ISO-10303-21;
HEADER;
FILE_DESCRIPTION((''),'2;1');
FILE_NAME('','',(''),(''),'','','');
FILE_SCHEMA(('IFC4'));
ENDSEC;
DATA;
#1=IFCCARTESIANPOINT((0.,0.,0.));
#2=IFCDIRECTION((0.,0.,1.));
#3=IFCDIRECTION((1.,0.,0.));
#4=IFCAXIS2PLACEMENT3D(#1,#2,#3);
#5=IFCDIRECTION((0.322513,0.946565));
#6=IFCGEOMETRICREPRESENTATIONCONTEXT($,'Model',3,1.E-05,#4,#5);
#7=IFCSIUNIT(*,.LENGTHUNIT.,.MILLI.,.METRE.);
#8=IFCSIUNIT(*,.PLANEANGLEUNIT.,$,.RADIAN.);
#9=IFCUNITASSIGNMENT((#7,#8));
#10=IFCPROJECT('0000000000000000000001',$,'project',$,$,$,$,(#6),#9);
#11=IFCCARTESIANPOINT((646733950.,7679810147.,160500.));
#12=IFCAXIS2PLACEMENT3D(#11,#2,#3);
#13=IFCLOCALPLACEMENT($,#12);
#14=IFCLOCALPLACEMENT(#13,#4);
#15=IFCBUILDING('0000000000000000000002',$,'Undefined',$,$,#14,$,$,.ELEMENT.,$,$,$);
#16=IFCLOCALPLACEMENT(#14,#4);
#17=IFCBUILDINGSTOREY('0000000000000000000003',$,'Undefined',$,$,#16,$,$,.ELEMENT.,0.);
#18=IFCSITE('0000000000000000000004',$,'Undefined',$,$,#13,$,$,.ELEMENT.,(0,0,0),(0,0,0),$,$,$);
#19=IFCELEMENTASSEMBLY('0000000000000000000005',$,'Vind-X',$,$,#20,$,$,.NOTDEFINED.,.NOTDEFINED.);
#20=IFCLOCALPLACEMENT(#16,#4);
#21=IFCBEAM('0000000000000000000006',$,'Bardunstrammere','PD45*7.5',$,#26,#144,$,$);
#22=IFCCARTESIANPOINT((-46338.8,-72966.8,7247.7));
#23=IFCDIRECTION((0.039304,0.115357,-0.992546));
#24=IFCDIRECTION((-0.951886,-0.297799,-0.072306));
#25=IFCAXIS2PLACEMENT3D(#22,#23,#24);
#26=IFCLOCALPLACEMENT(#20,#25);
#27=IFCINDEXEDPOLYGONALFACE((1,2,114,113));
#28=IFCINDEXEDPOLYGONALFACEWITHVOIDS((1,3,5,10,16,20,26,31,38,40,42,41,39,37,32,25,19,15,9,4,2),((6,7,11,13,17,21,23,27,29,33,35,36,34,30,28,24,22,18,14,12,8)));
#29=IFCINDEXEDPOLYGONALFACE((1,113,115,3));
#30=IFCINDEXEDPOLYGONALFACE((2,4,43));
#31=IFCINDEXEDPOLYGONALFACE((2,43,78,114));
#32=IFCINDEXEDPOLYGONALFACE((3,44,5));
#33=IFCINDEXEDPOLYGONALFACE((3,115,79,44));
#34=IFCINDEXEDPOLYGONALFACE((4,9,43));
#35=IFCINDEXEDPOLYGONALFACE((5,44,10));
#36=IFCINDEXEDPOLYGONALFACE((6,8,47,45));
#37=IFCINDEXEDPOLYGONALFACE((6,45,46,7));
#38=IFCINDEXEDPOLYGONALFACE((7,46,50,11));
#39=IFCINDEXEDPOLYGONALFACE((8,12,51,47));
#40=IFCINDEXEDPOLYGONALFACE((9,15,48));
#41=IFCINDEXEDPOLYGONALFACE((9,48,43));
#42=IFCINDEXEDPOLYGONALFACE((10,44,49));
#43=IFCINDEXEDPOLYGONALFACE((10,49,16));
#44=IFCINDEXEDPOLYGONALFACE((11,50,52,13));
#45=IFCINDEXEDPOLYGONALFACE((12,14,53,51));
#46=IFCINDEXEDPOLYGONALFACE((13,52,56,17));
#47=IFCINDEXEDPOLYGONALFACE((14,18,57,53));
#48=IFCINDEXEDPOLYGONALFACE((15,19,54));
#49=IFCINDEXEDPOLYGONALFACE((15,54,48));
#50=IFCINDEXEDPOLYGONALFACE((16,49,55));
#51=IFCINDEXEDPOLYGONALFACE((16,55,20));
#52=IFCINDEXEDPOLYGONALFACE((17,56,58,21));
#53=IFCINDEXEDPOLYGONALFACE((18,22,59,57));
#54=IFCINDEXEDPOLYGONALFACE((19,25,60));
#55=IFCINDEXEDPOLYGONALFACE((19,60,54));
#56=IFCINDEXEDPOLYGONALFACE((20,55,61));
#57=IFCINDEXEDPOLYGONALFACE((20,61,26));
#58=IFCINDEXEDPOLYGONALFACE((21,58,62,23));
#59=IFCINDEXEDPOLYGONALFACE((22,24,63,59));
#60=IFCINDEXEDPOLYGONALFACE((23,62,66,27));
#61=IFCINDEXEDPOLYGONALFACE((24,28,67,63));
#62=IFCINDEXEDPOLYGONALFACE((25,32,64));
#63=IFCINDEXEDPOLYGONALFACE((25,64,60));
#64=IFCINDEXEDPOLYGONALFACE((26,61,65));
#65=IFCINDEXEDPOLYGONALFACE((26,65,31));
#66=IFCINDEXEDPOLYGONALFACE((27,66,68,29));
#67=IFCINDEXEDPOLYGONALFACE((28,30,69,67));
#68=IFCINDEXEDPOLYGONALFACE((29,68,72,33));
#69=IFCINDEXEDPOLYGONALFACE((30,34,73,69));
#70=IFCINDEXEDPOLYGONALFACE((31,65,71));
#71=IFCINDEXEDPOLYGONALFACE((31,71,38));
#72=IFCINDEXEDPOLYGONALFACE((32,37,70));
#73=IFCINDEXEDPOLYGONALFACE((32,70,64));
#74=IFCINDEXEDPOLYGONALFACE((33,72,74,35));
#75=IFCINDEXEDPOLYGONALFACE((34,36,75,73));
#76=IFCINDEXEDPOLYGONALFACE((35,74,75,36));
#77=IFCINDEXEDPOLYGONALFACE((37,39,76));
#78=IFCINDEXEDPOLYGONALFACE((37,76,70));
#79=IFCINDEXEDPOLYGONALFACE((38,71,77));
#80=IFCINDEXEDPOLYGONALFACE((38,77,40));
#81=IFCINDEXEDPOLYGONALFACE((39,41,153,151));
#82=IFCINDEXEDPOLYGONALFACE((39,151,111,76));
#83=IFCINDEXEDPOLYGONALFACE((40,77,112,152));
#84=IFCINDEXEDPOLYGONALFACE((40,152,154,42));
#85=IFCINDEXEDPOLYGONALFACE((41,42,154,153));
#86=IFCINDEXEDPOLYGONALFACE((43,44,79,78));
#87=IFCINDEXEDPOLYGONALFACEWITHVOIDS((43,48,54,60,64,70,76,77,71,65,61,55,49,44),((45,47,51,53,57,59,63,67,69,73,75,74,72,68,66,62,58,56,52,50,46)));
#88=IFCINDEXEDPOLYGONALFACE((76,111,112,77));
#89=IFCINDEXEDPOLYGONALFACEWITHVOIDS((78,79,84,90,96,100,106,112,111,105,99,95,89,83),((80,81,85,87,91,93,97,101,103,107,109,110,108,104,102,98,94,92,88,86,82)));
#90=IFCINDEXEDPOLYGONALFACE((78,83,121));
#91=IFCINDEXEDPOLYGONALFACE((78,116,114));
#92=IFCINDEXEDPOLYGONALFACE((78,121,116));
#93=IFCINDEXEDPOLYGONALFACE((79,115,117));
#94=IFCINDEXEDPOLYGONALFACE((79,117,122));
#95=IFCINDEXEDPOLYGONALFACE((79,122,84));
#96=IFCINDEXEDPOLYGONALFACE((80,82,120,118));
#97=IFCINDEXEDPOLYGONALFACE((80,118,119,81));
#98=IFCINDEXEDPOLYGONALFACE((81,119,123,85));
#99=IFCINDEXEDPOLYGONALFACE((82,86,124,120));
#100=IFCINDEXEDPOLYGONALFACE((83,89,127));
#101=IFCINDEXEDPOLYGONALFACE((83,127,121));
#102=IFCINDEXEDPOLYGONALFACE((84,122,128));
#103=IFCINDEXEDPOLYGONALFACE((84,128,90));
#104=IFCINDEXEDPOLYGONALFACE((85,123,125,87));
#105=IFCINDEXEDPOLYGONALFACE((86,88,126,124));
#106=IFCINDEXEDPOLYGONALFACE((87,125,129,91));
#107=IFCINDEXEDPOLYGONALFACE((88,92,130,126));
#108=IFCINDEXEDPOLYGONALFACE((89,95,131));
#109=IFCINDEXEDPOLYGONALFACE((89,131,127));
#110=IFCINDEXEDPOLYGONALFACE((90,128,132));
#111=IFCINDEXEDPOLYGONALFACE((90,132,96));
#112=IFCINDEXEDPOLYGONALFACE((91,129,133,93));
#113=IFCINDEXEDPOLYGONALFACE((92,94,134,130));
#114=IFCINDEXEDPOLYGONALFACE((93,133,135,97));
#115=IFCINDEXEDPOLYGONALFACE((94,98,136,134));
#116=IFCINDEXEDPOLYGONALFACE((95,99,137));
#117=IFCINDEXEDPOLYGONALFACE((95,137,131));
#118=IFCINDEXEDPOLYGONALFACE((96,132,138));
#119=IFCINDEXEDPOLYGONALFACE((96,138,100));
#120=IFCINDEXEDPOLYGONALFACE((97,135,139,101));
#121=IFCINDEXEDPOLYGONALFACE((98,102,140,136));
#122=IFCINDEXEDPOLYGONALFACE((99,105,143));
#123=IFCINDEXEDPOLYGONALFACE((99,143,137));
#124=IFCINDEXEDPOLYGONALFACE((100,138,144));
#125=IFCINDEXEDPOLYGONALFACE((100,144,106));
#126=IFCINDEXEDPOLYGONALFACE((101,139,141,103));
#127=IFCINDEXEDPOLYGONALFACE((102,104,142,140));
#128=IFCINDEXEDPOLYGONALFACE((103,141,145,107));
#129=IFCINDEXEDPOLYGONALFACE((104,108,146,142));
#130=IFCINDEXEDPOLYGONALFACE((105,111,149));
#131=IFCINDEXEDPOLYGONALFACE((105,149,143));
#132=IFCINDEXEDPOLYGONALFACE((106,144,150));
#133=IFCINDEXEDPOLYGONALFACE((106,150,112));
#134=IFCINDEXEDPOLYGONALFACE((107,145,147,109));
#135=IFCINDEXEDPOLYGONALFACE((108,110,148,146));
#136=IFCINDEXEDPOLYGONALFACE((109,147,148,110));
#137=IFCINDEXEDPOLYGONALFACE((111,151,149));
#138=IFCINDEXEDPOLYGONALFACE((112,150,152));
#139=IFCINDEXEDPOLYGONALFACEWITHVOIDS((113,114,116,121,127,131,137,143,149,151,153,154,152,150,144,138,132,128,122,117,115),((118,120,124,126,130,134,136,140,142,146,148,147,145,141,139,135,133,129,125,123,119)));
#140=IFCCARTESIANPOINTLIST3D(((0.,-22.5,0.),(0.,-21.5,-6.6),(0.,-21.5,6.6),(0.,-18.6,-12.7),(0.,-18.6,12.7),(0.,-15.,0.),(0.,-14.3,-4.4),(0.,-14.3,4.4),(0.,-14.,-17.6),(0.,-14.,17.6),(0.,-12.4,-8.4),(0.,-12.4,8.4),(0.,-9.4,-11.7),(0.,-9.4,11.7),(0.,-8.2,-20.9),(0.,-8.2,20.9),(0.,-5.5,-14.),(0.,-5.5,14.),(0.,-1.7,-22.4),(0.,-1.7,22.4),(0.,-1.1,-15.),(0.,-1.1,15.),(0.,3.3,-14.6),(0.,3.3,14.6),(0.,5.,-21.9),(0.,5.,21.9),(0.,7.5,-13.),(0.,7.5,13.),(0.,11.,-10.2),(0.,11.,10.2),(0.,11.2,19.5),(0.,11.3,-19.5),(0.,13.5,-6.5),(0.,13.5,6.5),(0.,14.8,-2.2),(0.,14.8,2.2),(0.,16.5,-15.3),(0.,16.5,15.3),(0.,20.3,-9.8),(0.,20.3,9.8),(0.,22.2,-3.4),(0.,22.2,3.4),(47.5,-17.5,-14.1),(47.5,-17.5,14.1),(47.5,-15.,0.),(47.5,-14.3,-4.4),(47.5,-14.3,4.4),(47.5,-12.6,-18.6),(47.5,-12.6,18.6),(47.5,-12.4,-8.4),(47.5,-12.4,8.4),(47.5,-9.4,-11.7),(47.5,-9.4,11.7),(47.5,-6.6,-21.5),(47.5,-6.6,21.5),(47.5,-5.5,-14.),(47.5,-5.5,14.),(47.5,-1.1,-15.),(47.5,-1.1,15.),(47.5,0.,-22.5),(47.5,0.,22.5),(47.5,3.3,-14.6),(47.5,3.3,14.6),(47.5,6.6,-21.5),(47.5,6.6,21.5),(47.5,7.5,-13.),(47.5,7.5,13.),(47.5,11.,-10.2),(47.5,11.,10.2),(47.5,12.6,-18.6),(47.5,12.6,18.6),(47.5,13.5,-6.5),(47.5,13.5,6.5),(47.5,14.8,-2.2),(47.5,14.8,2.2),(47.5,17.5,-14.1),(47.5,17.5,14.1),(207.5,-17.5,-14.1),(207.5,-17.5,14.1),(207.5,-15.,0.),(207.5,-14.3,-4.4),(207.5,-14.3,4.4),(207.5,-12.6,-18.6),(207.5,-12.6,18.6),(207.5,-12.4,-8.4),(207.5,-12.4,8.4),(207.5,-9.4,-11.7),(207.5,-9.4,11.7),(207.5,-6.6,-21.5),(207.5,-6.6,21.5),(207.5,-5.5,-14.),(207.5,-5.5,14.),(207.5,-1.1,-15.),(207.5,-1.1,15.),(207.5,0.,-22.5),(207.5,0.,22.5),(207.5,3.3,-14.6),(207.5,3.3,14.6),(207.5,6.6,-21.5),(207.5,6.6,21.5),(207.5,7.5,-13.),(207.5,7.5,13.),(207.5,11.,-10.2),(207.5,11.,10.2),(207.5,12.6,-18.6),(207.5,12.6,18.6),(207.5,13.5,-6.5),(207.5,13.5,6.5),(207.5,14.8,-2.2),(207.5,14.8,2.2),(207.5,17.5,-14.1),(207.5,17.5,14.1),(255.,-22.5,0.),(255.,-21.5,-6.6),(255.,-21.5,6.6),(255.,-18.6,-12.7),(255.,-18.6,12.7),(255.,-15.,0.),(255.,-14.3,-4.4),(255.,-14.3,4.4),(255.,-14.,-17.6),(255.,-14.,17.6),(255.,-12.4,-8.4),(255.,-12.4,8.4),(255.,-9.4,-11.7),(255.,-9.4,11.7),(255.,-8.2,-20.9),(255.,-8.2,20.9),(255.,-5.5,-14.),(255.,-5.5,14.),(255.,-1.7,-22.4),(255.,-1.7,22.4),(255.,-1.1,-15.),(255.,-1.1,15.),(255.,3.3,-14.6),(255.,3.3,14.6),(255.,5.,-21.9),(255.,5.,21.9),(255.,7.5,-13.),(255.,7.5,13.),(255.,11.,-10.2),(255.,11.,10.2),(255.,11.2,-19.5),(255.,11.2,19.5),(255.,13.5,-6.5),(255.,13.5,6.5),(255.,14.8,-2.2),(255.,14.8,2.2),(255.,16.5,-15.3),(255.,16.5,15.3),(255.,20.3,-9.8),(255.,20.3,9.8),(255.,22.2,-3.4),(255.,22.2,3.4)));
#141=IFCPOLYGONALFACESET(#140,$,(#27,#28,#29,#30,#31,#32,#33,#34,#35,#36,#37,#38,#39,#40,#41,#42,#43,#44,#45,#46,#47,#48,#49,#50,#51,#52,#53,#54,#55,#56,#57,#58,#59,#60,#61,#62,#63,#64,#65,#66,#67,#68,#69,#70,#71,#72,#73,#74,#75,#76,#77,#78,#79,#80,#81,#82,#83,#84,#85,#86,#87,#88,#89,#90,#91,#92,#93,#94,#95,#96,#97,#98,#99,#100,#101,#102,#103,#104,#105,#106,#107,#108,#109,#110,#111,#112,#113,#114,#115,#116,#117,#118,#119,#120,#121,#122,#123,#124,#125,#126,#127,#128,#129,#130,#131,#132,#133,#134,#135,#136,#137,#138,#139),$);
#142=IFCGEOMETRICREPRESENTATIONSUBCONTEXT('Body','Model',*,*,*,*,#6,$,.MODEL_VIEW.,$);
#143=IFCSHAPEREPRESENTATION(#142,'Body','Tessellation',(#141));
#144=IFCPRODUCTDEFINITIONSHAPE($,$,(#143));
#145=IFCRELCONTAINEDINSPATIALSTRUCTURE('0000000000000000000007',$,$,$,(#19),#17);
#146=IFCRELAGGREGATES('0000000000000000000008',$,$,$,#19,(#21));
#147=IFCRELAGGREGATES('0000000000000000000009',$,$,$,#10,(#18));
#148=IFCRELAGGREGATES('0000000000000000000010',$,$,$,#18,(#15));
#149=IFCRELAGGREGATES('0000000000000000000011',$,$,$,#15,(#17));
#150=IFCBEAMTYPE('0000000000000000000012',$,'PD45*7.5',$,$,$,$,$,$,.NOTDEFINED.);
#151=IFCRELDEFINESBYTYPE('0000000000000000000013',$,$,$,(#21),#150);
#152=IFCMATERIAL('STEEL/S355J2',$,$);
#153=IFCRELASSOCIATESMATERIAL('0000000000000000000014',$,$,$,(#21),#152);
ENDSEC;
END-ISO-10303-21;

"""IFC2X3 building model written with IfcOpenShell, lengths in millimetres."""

from ifc_helpers import new_model, si_unit, direction, frame, origin_with_axes, origin_2d_with_axis, place, context, subcontext, project, spatial, rectangle, hollow_circle, extrude, boolean, material, type_object, element, aggregate, save


model = new_model("IFC2X3")

# Units and contexts
model_context = context("Model", 3, precision=1e-05, world=origin_with_axes(), true_north=direction((0.322513, 0.946565)))
body_context = subcontext(model_context, "Body", "Model", "MODEL_VIEW")
ifc_project = project(units=[si_unit("LENGTHUNIT", "METRE", prefix="MILLI"), si_unit("PLANEANGLEUNIT", "RADIAN")], contexts=[model_context])

# Site, building, storey
site_placement = place(None, frame((646733950.0, 7679810147.0, 160500.0), z_axis=(0.0, 0.0, 1.0), x_axis=(1.0, 0.0, 0.0)))
site = spatial("IfcSite", under=ifc_project, at=site_placement, Name="Undefined", CompositionType="ELEMENT", RefLatitude=(0, 0, 0), RefLongitude=(0, 0, 0))
building_placement = place(site_placement, origin_with_axes())
building = spatial("IfcBuilding", under=site, at=building_placement, Name="Undefined", CompositionType="ELEMENT")
storey_placement = place(building_placement, origin_with_axes())
storey = spatial("IfcBuildingStorey", under=building, at=storey_placement, Name="Undefined", CompositionType="ELEMENT", Elevation=0.0)

# Element assembly, beam
assembly_1_placement = place(storey_placement, origin_with_axes())
assembly_1 = element("IfcElementAssembly", 1, at=assembly_1_placement, inside=storey, Name="Vind-X", AssemblyPlace="NOTDEFINED", PredefinedType="NOTDEFINED")
ifc_material_1 = material(Name="STEEL/S355J2")
beam_type = type_object("IfcBeamType", Name="PD45*7.5", PredefinedType="NOTDEFINED")
beam_1_placement = place(assembly_1_placement, frame((-46338.8, -72966.8, 7247.7), z_axis=(0.039304, 0.115357, -0.992546), x_axis=(-0.951886, -0.297799, -0.072306)))
beam_1 = element("IfcBeam", 2, at=beam_1_placement, type_object=beam_type, material=ifc_material_1, Name="Bardunstrammere", Description="PD45*7.5", context=body_context, shape_type="CSG", body=[
    boolean("DIFFERENCE", extrude(hollow_circle(Radius=22.5, WallThickness=7.5, at=origin_2d_with_axis()), frame((255.0, 0.0, 0.0), z_axis=(-1.0, 0.0, 0.0), x_axis=(0.0, -1.0, 0.0)), (0.0, 0.0, 1.0), 255.0), extrude(rectangle(XDim=35.0, YDim=90.0, at=origin_2d_with_axis()), frame((207.5, 0.0, 0.0), z_axis=(-1.0, 0.0, 0.0), x_axis=(0.0, -1.0, 0.0)), (0.0, 0.0, 1.0), 160.0)),
])

aggregate(assembly_1, [beam_1])

save(model, "model.ifc")
